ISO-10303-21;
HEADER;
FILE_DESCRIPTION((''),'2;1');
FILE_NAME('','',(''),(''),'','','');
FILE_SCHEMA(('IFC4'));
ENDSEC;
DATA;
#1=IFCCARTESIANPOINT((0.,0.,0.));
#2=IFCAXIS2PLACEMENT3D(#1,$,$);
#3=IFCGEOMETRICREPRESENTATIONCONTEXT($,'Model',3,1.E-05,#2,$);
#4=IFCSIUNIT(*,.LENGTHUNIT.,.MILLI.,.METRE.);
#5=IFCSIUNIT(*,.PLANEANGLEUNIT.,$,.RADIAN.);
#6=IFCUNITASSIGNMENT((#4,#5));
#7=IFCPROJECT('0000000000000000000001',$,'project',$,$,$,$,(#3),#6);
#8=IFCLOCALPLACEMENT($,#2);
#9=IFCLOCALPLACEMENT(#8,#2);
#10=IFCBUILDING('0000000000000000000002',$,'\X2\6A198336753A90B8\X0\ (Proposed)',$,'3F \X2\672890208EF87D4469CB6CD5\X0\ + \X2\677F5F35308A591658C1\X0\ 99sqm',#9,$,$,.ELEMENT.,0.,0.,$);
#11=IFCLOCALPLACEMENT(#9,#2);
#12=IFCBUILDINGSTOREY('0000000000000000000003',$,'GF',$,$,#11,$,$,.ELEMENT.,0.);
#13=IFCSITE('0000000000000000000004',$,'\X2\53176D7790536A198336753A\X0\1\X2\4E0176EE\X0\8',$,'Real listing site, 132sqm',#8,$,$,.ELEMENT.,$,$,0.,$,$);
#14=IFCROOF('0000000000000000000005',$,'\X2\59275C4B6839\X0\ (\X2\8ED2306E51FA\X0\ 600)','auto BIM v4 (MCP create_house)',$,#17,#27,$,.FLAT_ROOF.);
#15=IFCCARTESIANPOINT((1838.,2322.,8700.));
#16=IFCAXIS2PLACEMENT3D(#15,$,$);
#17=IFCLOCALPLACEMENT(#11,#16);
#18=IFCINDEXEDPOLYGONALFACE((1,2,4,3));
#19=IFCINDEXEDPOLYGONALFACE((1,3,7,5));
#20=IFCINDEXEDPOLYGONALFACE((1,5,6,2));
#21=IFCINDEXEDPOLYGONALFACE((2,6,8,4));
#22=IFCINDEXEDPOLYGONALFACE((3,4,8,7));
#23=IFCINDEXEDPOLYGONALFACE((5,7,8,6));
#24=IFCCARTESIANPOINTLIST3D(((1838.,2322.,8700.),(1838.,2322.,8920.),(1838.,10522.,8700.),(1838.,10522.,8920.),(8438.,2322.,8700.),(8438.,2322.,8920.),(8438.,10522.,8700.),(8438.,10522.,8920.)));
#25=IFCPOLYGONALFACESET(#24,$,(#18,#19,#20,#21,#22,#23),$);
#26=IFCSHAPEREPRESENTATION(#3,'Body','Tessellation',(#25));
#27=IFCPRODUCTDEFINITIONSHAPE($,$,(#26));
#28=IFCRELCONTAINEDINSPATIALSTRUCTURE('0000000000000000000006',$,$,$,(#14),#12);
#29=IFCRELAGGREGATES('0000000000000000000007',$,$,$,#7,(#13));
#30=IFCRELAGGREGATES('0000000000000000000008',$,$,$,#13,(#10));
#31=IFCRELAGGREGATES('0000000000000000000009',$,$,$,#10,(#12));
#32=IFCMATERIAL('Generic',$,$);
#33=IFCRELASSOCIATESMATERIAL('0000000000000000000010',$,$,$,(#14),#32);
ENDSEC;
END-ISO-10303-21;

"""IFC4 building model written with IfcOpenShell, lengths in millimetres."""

from ifc_helpers import new_model, si_unit, frame, frame_2d, origin, place, context, project, spatial, rectangle, extrude, material, element, save


model = new_model("IFC4")

# Units and contexts
model_context = context("Model", 3, precision=1e-05, world=origin())
ifc_project = project(units=[si_unit("LENGTHUNIT", "METRE", prefix="MILLI"), si_unit("PLANEANGLEUNIT", "RADIAN")], contexts=[model_context])

# Site, building, storey
site_placement = place(None, origin())
site = spatial("IfcSite", under=ifc_project, at=site_placement, Name="北海道標茶町1丁目8", ObjectType="Real listing site, 132sqm", CompositionType="ELEMENT", RefElevation=0.0)
building_placement = place(site_placement, origin())
building = spatial("IfcBuilding", under=site, at=building_placement, Name="標茶町邸 (Proposed)", ObjectType="3F 木造軸組構法 + 板張り外壁 99sqm", CompositionType="ELEMENT", ElevationOfRefHeight=0.0, ElevationOfTerrain=0.0)
storey_placement = place(building_placement, origin())
storey = spatial("IfcBuildingStorey", under=building, at=storey_placement, Name="GF", CompositionType="ELEMENT", Elevation=0.0)

# Shared definitions
ifc_material = material(Name="Generic")

# Roof
roof_placement = place(storey_placement, frame((1838.0, 2322.0, 8700.0)))
element("IfcRoof", 1, at=roof_placement, inside=storey, material=ifc_material, Name="大屋根 (軒の出 600)", Description="auto BIM v4 (MCP create_house)", PredefinedType="FLAT_ROOF", context=model_context, shape_type="SweptSolid", body=[
    extrude(rectangle(XDim=6600.0, YDim=8200.0, at=frame_2d((3300.0, 4100.0))), frame((1838.0, 2322.0, 8700.0)), (0.0, 0.0, 1.0), 220.0),
])

save(model, "model.ifc")
